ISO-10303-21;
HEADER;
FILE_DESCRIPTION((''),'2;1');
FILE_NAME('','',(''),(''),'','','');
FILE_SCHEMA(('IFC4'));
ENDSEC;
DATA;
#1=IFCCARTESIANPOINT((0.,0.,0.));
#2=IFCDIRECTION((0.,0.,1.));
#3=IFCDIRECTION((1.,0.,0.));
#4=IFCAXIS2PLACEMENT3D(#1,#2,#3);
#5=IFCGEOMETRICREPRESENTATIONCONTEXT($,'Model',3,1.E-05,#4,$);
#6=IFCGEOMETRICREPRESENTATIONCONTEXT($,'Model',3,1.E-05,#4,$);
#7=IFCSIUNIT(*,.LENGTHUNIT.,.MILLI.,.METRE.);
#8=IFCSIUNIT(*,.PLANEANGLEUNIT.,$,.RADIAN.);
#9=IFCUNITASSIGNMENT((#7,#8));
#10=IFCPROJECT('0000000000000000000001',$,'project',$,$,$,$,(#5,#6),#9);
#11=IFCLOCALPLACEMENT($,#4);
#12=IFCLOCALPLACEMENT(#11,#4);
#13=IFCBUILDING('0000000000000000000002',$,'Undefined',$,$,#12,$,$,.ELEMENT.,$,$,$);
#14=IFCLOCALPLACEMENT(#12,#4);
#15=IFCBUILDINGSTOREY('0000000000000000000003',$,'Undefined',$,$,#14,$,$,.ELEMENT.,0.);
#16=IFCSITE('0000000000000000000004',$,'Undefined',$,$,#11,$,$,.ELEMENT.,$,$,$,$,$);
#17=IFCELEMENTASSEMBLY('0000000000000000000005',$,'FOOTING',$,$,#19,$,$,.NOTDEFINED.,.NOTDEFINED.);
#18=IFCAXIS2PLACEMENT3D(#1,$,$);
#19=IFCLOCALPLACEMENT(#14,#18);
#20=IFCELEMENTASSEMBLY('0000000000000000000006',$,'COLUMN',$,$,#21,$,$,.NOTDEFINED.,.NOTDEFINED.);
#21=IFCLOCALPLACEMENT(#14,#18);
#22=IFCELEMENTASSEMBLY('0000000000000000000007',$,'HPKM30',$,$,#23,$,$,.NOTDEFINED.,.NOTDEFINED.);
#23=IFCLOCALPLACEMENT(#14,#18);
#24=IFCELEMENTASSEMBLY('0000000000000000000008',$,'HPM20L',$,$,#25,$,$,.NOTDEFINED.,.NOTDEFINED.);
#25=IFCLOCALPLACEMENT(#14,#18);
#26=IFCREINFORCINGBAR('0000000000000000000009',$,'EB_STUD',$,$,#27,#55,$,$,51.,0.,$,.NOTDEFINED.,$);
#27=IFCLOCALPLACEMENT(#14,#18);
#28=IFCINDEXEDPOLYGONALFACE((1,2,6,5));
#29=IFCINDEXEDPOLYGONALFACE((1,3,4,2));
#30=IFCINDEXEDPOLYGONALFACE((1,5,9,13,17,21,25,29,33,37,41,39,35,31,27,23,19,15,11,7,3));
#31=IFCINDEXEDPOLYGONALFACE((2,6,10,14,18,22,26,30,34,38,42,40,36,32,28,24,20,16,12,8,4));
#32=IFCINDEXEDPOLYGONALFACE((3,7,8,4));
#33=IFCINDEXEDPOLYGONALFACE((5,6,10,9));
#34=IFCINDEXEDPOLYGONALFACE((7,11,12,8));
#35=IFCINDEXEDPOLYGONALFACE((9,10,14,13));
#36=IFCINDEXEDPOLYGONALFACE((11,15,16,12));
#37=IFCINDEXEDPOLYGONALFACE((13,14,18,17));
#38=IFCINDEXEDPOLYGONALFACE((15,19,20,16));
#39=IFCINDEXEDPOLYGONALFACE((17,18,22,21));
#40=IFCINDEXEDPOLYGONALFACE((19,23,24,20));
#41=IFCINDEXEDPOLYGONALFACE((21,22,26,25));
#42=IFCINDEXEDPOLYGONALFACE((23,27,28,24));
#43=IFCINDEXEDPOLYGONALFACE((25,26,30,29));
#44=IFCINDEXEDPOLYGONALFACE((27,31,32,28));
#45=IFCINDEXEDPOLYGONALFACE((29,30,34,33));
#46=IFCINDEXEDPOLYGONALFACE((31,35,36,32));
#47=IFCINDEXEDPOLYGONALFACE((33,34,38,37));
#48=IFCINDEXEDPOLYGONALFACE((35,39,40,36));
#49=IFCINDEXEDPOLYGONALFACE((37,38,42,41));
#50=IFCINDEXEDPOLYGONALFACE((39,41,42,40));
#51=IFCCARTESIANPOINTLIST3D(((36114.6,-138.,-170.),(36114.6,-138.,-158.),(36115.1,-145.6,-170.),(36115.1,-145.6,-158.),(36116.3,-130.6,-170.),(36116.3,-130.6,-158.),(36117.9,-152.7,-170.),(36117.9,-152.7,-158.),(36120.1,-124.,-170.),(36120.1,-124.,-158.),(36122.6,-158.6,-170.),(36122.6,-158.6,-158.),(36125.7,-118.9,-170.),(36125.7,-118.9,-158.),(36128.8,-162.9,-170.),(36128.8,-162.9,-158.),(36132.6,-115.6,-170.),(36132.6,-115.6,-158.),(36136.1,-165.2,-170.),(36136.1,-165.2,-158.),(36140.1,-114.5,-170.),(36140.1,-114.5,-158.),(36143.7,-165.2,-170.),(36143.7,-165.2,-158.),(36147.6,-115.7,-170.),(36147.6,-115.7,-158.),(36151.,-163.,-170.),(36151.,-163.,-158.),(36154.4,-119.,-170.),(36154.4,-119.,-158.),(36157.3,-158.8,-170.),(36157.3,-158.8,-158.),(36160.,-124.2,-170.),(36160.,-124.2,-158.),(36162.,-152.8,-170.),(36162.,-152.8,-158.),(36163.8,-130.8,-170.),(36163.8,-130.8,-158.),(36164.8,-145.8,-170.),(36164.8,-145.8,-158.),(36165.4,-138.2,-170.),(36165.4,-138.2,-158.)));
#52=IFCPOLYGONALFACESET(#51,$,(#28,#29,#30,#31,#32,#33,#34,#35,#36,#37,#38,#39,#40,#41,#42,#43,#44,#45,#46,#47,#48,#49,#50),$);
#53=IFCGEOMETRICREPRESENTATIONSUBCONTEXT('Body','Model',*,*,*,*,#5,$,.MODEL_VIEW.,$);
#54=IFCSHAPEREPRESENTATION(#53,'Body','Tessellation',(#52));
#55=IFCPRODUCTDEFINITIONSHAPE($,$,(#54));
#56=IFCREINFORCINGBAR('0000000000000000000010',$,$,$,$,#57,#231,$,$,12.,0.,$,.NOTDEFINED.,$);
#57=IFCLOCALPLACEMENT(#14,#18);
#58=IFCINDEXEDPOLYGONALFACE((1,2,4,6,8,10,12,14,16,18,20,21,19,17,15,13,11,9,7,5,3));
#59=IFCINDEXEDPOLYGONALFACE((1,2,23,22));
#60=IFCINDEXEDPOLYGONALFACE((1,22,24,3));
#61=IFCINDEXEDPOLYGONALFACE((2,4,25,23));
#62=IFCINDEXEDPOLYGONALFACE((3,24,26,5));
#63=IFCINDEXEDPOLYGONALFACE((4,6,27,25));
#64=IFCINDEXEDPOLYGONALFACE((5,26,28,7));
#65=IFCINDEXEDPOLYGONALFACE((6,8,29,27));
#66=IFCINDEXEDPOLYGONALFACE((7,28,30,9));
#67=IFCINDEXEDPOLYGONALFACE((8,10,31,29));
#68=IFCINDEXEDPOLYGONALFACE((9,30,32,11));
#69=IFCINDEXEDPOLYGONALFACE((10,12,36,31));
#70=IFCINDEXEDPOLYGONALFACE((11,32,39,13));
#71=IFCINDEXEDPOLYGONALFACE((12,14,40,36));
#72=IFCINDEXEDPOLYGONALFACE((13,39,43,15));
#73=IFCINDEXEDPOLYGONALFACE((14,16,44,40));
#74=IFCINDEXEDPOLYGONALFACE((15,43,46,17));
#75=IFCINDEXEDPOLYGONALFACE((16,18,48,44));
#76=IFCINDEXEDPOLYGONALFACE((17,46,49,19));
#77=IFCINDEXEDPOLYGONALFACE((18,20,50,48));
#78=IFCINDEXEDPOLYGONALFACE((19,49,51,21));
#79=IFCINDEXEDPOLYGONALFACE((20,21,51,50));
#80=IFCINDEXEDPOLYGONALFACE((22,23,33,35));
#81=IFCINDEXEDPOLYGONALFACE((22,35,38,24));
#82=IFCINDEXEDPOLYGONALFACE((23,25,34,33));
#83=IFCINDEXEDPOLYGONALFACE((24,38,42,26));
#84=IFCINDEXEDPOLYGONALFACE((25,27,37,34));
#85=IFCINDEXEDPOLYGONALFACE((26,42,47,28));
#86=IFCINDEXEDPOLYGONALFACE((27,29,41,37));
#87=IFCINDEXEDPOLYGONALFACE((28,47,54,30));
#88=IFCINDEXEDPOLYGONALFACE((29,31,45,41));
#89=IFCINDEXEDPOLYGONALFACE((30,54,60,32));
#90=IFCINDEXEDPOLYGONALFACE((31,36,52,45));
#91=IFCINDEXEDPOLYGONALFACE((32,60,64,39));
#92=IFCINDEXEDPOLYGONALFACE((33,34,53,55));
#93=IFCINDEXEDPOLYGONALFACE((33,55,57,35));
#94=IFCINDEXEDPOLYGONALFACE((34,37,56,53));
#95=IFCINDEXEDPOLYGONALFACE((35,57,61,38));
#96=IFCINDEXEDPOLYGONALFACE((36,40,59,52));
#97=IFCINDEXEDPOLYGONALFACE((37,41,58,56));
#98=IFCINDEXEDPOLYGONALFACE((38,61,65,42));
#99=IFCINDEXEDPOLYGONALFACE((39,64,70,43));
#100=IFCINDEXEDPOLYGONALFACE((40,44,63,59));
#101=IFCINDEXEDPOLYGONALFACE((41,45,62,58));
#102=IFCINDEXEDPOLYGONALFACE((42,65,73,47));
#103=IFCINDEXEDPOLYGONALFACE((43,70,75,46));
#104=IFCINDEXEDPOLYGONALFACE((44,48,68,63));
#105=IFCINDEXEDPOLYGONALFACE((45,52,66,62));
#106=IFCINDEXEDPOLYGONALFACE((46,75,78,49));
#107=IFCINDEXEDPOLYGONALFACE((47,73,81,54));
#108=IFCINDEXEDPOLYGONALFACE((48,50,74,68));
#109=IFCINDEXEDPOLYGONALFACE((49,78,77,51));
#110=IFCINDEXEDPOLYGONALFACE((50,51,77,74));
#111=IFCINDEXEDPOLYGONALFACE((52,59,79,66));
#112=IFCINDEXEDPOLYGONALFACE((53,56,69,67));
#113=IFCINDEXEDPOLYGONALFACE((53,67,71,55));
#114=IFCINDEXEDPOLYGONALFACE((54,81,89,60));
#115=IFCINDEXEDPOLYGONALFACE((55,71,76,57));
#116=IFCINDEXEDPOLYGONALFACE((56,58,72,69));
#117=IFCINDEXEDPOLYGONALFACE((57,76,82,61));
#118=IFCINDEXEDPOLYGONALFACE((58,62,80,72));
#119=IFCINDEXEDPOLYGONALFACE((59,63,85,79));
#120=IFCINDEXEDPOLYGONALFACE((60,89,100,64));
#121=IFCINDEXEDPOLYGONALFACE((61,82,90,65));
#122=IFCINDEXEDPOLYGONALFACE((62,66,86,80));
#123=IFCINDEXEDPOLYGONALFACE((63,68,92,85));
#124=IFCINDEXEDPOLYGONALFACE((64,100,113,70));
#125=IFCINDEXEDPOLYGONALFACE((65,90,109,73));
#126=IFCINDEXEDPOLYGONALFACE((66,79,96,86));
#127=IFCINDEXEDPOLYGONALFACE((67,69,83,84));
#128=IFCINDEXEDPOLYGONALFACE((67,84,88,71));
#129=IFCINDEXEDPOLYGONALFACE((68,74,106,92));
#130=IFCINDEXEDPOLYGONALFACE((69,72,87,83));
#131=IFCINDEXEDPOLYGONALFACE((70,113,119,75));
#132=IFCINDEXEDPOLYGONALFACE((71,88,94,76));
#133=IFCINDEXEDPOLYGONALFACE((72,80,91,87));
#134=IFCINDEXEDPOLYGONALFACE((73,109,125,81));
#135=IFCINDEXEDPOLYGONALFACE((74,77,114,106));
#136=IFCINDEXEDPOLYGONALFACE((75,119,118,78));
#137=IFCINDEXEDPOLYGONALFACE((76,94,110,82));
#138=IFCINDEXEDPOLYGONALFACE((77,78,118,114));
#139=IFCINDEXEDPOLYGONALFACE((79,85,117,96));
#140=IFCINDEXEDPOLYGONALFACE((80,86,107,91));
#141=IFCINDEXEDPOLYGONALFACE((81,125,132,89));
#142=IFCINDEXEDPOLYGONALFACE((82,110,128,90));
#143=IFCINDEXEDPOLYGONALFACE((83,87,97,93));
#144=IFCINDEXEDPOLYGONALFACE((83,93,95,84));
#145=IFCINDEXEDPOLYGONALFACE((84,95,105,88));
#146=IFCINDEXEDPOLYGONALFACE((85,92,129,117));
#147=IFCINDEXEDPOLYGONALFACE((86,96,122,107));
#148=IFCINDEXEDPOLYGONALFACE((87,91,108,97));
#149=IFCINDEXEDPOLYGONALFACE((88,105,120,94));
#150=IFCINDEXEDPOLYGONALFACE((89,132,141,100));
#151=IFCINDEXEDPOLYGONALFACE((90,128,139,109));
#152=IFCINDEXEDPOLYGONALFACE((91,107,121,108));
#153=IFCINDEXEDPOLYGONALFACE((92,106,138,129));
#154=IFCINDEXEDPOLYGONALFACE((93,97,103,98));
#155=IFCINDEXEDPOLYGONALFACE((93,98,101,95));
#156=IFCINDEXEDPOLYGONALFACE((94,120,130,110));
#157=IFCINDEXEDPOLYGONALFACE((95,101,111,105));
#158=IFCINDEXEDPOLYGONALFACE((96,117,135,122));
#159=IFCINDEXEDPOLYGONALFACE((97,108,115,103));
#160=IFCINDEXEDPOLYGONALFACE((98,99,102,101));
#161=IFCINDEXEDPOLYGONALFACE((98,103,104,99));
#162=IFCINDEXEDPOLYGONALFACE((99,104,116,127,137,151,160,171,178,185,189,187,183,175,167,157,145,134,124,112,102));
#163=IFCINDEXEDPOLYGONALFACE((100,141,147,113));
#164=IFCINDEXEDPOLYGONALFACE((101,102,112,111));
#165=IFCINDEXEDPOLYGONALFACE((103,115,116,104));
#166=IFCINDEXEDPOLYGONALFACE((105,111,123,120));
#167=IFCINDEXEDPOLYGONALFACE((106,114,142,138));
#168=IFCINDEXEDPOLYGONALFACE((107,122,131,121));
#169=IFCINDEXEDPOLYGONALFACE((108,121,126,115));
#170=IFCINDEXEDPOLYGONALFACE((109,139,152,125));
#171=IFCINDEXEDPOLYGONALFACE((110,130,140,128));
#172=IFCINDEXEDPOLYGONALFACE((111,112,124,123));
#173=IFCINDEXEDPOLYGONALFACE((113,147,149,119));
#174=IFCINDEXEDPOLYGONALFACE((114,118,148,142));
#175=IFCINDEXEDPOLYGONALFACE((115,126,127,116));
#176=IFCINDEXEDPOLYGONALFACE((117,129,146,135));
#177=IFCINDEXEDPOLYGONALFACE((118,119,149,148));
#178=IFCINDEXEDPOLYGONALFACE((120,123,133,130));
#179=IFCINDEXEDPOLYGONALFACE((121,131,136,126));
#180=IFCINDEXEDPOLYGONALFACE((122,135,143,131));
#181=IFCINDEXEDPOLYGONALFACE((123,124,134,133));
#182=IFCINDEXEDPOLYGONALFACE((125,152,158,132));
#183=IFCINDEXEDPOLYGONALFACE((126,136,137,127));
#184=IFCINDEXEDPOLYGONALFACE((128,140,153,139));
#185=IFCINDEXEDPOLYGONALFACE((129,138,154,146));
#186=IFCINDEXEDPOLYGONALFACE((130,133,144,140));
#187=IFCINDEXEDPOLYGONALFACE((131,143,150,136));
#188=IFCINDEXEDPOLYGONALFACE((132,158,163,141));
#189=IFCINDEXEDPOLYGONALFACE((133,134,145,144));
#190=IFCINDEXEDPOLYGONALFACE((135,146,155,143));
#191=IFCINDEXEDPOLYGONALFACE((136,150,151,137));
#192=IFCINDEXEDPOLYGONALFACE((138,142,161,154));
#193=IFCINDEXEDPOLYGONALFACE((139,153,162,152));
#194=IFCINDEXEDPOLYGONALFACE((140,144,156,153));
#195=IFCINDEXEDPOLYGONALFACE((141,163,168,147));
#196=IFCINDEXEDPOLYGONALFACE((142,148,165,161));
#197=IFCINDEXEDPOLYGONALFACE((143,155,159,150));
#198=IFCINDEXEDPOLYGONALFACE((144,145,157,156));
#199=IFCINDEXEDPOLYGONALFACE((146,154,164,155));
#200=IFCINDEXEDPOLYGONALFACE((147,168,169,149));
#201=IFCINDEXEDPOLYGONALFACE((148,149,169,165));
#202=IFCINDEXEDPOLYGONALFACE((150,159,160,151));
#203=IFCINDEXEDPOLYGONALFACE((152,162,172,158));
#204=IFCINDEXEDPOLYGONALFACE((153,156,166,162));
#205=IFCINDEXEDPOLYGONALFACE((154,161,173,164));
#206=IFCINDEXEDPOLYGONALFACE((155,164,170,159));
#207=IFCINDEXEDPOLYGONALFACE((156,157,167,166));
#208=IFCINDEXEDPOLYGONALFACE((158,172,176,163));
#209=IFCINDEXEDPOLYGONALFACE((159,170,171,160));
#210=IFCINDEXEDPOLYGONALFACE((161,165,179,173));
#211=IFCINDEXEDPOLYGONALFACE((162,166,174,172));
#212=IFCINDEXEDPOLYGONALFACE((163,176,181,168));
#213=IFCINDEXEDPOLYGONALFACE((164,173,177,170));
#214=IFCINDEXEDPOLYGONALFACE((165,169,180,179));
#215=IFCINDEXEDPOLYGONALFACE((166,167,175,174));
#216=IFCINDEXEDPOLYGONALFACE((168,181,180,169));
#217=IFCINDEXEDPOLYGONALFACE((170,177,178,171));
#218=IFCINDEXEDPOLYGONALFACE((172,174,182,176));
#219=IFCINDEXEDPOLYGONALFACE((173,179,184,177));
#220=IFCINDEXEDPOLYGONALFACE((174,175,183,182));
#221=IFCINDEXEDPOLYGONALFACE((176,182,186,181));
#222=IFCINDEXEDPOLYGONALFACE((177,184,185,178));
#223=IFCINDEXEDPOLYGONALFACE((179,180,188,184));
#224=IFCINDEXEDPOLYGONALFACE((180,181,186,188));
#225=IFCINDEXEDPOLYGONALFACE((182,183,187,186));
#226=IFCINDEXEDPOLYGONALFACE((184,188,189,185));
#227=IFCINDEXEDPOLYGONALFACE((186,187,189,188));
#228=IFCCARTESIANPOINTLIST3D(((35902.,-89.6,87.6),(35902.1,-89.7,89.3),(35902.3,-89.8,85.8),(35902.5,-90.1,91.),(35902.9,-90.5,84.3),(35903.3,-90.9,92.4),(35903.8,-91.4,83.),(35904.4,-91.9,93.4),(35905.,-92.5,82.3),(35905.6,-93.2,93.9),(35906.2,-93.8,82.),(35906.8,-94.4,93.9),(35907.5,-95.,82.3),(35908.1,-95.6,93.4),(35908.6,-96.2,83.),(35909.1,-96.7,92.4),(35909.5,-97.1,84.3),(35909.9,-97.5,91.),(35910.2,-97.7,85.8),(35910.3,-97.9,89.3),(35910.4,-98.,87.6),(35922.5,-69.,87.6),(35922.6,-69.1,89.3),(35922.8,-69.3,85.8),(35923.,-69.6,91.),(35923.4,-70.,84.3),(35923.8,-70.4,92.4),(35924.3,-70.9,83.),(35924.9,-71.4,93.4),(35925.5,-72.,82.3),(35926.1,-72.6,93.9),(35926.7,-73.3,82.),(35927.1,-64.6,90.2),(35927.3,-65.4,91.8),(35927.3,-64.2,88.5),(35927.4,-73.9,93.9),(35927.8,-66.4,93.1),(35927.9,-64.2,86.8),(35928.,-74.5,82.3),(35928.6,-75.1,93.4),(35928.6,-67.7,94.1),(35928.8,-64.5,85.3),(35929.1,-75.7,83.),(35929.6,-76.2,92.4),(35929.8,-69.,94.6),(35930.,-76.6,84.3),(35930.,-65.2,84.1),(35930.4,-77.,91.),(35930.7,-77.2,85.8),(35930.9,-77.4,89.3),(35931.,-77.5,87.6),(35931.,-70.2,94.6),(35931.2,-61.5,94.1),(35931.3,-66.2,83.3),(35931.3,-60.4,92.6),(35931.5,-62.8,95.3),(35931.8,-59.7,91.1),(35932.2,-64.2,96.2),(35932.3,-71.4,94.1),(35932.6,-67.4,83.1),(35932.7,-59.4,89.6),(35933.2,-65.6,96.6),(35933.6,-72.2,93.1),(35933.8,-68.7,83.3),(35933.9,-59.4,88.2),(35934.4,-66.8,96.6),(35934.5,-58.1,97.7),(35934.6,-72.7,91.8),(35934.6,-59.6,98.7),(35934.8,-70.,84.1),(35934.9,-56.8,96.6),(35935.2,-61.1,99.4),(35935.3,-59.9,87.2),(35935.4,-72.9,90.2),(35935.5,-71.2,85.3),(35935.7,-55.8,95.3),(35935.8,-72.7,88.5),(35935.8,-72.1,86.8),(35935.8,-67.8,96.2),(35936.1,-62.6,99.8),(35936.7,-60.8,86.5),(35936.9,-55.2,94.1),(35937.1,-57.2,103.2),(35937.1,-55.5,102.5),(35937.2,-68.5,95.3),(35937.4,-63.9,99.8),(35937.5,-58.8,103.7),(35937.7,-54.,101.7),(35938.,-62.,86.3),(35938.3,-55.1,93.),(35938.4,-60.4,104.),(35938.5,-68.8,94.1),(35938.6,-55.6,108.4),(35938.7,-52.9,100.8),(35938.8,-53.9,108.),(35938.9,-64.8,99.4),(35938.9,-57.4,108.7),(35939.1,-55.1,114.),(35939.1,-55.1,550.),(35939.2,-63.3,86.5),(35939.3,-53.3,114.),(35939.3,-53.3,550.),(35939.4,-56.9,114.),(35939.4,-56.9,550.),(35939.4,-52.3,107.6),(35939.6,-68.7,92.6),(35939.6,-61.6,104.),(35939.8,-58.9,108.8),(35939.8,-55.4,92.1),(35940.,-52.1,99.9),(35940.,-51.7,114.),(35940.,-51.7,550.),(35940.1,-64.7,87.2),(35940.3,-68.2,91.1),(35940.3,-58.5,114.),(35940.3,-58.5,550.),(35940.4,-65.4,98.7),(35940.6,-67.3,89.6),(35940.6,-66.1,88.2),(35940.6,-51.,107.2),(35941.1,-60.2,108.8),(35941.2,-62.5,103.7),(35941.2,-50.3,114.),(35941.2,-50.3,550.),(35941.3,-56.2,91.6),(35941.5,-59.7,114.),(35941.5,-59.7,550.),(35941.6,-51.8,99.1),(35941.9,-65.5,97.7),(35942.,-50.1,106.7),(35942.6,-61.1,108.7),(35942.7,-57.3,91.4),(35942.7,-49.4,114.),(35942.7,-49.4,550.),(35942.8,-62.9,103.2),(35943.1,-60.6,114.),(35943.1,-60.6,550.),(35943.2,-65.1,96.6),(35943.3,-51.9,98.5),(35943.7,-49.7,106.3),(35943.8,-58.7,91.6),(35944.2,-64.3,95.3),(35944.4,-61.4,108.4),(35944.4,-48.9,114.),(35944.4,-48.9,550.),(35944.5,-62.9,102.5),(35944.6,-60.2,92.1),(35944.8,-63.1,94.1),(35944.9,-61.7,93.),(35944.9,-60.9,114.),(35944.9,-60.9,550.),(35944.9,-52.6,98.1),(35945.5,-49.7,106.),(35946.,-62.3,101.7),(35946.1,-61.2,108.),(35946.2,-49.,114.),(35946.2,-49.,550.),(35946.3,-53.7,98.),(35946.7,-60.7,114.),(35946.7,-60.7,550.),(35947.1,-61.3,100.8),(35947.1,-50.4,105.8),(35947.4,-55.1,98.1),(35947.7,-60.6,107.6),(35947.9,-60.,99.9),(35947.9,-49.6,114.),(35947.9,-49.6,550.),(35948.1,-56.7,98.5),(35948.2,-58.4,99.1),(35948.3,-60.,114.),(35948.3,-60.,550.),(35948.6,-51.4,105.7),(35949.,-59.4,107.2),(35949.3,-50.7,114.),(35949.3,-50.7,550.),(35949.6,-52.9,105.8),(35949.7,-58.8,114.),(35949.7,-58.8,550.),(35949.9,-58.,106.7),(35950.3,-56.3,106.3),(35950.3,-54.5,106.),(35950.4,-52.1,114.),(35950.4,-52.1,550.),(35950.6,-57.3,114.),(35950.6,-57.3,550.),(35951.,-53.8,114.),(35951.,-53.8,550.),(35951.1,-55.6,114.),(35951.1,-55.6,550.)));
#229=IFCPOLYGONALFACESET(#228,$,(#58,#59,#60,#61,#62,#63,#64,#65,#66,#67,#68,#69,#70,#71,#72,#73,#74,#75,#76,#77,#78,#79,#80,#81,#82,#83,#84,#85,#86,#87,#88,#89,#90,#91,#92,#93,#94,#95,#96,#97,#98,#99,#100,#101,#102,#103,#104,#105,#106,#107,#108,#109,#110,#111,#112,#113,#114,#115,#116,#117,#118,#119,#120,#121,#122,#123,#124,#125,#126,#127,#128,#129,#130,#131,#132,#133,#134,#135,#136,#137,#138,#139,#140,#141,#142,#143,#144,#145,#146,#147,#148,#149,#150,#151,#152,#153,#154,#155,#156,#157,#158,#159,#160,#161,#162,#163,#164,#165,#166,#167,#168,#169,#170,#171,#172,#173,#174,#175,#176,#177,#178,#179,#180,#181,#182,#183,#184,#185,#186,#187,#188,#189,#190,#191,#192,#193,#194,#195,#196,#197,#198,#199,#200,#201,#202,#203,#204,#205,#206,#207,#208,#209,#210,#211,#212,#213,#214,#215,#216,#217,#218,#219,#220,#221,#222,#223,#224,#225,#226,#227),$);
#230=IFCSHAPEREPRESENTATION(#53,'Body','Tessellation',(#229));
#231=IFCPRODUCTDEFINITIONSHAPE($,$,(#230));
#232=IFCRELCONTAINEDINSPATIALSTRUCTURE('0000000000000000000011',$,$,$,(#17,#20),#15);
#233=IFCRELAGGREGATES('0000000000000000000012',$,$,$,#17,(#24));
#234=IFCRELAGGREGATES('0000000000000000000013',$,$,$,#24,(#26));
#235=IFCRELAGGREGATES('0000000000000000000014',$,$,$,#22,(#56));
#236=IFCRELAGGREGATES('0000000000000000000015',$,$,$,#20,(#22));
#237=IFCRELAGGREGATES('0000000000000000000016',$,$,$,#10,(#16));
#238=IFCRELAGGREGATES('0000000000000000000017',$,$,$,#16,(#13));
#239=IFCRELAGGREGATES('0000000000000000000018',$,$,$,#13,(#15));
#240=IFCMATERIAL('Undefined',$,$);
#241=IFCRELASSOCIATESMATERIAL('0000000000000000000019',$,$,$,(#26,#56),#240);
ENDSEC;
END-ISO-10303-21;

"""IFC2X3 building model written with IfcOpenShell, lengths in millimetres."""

from ifc_helpers import new_model, entity, si_unit, frame, origin_with_axes, place, context, subcontext, project, spatial, source, transform, mapped, material, element, aggregate, save


model = new_model("IFC2X3")

# Units and contexts
model_context_1 = context("Model", 3, precision=1e-05, world=origin_with_axes())
model_context_2 = context("Model", 3, precision=1e-05, world=origin_with_axes())
body_context = subcontext(model_context_1, "Body", "Model", "MODEL_VIEW")
ifc_project = project(units=[si_unit("LENGTHUNIT", "METRE", prefix="MILLI"), si_unit("PLANEANGLEUNIT", "RADIAN")], contexts=[model_context_1, model_context_2])

# Site, building, storey
site_placement = place(None, origin_with_axes())
site = spatial("IfcSite", under=ifc_project, at=site_placement, Name="Undefined", CompositionType="ELEMENT")
building_placement = place(site_placement, origin_with_axes())
building = spatial("IfcBuilding", under=site, at=building_placement, Name="Undefined", CompositionType="ELEMENT")
storey_placement = place(building_placement, origin_with_axes())
storey = spatial("IfcBuildingStorey", under=building, at=storey_placement, Name="Undefined", CompositionType="ELEMENT", Elevation=0.0)

# Element assembly
assembly_1_placement = place(storey_placement, origin_with_axes())
assembly_1 = element("IfcElementAssembly", 1, at=assembly_1_placement, inside=storey, Name="FOOTING", AssemblyPlace="NOTDEFINED", PredefinedType="NOTDEFINED")

# Element assemblies
assembly_2_placement = place(storey_placement, origin_with_axes())
assembly_2 = element("IfcElementAssembly", 2, at=assembly_2_placement, inside=storey, Name="COLUMN", AssemblyPlace="NOTDEFINED", PredefinedType="NOTDEFINED")
assembly_3_placement = place(assembly_2_placement, origin_with_axes())
assembly_3 = element("IfcElementAssembly", 3, at=assembly_3_placement, Name="HPKM30", AssemblyPlace="NOTDEFINED", PredefinedType="NOTDEFINED")

# Shared definitions
ifc_material_1 = material(Name="Undefined")

# Element assembly
assembly_4_placement = place(assembly_1_placement, origin_with_axes())
assembly_4 = element("IfcElementAssembly", 4, at=assembly_4_placement, Name="HPM20L", AssemblyPlace="NOTDEFINED", PredefinedType="NOTDEFINED")
aggregate(assembly_1, [assembly_4])

# Reinforcing bars
shared_shape_1 = source(origin_with_axes(), body_context, "Body", "AdvancedSweptSolid", [
    entity("IfcSweptDiskSolid", entity("IfcTrimmedCurve", entity("IfcLine", entity("IfcCartesianPoint", [0.0, 0.0, 0.0]), entity("IfcVector", entity("IfcDirection", [1.0, 0.0, 0.0]), 1.0)), [entity("IfcParameterValue", 0.0)], [entity("IfcParameterValue", 12.0)], True, "PARAMETER"), 25.5, None, 0.0, 12.0),
])
reinforcing_bar_1_placement = place(assembly_4_placement, frame((36140.0, -140.0, -158.0), z_axis=(0.003874, 0.999992, 0.0), x_axis=(0.0, 0.0, -1.0)))
reinforcing_bar_1 = element("IfcReinforcingBar", 5, at=reinforcing_bar_1_placement, material=ifc_material_1, Name="EB_STUD", BarRole="NOTDEFINED", CrossSectionArea=0.0, NominalDiameter=51.0, context=body_context, shape_type="MappedRepresentation", body=[
    mapped(shared_shape_1, transform((0.0, 0.0, 0.0))),
])
aggregate(assembly_4, [reinforcing_bar_1])
shared_shape_2 = source(origin_with_axes(), body_context, "Body", "AdvancedSweptSolid", [
    entity("IfcSweptDiskSolid", entity("IfcCompositeCurve", [entity("IfcCompositeCurveSegment", "CONTINUOUS", True, entity("IfcTrimmedCurve", entity("IfcLine", entity("IfcCartesianPoint", [0.0, 0.0, 0.0]), entity("IfcVector", entity("IfcDirection", [0.0, 0.0, -1.0]), 1.0)), [entity("IfcParameterValue", 0.0)], [entity("IfcParameterValue", 29.0)], True, "PARAMETER")), entity("IfcCompositeCurveSegment", "CONTINUOUS", True, entity("IfcTrimmedCurve", entity("IfcCircle", entity("IfcAxis2Placement3D", entity("IfcCartesianPoint", [26.0, 0.0, -29.0]), entity("IfcDirection", [0.0, -1.0, 0.0]), entity("IfcDirection", [-1.0, 0.0, 0.0])), 26.0), [entity("IfcParameterValue", 0.0)], [entity("IfcParameterValue", 1.570796)], True, "PARAMETER")), entity("IfcCompositeCurveSegment", "DISCONTINUOUS", True, entity("IfcTrimmedCurve", entity("IfcLine", entity("IfcCartesianPoint", [26.0, 0.0, -55.0]), entity("IfcVector", entity("IfcDirection", [1.0, 0.0, 0.0]), 1.0)), [entity("IfcParameterValue", 0.0)], [entity("IfcParameterValue", 436.0)], True, "PARAMETER"))], False), 6.0, None, 0.0, 466.6),
])
reinforcing_bar_2_placement = place(assembly_3_placement, frame((35945.1, -54.9, 88.0), z_axis=(-0.707107, -0.707107, 0.0), x_axis=(0.0, 0.0, 1.0)))
reinforcing_bar_2 = element("IfcReinforcingBar", 6, at=reinforcing_bar_2_placement, material=ifc_material_1, BarRole="NOTDEFINED", CrossSectionArea=0.0, NominalDiameter=12.0, context=body_context, shape_type="MappedRepresentation", body=[
    mapped(shared_shape_2, transform((0.0, 0.0, 55.0))),
])
aggregate(assembly_3, [reinforcing_bar_2])
aggregate(assembly_2, [assembly_3])

save(model, "model.ifc")
